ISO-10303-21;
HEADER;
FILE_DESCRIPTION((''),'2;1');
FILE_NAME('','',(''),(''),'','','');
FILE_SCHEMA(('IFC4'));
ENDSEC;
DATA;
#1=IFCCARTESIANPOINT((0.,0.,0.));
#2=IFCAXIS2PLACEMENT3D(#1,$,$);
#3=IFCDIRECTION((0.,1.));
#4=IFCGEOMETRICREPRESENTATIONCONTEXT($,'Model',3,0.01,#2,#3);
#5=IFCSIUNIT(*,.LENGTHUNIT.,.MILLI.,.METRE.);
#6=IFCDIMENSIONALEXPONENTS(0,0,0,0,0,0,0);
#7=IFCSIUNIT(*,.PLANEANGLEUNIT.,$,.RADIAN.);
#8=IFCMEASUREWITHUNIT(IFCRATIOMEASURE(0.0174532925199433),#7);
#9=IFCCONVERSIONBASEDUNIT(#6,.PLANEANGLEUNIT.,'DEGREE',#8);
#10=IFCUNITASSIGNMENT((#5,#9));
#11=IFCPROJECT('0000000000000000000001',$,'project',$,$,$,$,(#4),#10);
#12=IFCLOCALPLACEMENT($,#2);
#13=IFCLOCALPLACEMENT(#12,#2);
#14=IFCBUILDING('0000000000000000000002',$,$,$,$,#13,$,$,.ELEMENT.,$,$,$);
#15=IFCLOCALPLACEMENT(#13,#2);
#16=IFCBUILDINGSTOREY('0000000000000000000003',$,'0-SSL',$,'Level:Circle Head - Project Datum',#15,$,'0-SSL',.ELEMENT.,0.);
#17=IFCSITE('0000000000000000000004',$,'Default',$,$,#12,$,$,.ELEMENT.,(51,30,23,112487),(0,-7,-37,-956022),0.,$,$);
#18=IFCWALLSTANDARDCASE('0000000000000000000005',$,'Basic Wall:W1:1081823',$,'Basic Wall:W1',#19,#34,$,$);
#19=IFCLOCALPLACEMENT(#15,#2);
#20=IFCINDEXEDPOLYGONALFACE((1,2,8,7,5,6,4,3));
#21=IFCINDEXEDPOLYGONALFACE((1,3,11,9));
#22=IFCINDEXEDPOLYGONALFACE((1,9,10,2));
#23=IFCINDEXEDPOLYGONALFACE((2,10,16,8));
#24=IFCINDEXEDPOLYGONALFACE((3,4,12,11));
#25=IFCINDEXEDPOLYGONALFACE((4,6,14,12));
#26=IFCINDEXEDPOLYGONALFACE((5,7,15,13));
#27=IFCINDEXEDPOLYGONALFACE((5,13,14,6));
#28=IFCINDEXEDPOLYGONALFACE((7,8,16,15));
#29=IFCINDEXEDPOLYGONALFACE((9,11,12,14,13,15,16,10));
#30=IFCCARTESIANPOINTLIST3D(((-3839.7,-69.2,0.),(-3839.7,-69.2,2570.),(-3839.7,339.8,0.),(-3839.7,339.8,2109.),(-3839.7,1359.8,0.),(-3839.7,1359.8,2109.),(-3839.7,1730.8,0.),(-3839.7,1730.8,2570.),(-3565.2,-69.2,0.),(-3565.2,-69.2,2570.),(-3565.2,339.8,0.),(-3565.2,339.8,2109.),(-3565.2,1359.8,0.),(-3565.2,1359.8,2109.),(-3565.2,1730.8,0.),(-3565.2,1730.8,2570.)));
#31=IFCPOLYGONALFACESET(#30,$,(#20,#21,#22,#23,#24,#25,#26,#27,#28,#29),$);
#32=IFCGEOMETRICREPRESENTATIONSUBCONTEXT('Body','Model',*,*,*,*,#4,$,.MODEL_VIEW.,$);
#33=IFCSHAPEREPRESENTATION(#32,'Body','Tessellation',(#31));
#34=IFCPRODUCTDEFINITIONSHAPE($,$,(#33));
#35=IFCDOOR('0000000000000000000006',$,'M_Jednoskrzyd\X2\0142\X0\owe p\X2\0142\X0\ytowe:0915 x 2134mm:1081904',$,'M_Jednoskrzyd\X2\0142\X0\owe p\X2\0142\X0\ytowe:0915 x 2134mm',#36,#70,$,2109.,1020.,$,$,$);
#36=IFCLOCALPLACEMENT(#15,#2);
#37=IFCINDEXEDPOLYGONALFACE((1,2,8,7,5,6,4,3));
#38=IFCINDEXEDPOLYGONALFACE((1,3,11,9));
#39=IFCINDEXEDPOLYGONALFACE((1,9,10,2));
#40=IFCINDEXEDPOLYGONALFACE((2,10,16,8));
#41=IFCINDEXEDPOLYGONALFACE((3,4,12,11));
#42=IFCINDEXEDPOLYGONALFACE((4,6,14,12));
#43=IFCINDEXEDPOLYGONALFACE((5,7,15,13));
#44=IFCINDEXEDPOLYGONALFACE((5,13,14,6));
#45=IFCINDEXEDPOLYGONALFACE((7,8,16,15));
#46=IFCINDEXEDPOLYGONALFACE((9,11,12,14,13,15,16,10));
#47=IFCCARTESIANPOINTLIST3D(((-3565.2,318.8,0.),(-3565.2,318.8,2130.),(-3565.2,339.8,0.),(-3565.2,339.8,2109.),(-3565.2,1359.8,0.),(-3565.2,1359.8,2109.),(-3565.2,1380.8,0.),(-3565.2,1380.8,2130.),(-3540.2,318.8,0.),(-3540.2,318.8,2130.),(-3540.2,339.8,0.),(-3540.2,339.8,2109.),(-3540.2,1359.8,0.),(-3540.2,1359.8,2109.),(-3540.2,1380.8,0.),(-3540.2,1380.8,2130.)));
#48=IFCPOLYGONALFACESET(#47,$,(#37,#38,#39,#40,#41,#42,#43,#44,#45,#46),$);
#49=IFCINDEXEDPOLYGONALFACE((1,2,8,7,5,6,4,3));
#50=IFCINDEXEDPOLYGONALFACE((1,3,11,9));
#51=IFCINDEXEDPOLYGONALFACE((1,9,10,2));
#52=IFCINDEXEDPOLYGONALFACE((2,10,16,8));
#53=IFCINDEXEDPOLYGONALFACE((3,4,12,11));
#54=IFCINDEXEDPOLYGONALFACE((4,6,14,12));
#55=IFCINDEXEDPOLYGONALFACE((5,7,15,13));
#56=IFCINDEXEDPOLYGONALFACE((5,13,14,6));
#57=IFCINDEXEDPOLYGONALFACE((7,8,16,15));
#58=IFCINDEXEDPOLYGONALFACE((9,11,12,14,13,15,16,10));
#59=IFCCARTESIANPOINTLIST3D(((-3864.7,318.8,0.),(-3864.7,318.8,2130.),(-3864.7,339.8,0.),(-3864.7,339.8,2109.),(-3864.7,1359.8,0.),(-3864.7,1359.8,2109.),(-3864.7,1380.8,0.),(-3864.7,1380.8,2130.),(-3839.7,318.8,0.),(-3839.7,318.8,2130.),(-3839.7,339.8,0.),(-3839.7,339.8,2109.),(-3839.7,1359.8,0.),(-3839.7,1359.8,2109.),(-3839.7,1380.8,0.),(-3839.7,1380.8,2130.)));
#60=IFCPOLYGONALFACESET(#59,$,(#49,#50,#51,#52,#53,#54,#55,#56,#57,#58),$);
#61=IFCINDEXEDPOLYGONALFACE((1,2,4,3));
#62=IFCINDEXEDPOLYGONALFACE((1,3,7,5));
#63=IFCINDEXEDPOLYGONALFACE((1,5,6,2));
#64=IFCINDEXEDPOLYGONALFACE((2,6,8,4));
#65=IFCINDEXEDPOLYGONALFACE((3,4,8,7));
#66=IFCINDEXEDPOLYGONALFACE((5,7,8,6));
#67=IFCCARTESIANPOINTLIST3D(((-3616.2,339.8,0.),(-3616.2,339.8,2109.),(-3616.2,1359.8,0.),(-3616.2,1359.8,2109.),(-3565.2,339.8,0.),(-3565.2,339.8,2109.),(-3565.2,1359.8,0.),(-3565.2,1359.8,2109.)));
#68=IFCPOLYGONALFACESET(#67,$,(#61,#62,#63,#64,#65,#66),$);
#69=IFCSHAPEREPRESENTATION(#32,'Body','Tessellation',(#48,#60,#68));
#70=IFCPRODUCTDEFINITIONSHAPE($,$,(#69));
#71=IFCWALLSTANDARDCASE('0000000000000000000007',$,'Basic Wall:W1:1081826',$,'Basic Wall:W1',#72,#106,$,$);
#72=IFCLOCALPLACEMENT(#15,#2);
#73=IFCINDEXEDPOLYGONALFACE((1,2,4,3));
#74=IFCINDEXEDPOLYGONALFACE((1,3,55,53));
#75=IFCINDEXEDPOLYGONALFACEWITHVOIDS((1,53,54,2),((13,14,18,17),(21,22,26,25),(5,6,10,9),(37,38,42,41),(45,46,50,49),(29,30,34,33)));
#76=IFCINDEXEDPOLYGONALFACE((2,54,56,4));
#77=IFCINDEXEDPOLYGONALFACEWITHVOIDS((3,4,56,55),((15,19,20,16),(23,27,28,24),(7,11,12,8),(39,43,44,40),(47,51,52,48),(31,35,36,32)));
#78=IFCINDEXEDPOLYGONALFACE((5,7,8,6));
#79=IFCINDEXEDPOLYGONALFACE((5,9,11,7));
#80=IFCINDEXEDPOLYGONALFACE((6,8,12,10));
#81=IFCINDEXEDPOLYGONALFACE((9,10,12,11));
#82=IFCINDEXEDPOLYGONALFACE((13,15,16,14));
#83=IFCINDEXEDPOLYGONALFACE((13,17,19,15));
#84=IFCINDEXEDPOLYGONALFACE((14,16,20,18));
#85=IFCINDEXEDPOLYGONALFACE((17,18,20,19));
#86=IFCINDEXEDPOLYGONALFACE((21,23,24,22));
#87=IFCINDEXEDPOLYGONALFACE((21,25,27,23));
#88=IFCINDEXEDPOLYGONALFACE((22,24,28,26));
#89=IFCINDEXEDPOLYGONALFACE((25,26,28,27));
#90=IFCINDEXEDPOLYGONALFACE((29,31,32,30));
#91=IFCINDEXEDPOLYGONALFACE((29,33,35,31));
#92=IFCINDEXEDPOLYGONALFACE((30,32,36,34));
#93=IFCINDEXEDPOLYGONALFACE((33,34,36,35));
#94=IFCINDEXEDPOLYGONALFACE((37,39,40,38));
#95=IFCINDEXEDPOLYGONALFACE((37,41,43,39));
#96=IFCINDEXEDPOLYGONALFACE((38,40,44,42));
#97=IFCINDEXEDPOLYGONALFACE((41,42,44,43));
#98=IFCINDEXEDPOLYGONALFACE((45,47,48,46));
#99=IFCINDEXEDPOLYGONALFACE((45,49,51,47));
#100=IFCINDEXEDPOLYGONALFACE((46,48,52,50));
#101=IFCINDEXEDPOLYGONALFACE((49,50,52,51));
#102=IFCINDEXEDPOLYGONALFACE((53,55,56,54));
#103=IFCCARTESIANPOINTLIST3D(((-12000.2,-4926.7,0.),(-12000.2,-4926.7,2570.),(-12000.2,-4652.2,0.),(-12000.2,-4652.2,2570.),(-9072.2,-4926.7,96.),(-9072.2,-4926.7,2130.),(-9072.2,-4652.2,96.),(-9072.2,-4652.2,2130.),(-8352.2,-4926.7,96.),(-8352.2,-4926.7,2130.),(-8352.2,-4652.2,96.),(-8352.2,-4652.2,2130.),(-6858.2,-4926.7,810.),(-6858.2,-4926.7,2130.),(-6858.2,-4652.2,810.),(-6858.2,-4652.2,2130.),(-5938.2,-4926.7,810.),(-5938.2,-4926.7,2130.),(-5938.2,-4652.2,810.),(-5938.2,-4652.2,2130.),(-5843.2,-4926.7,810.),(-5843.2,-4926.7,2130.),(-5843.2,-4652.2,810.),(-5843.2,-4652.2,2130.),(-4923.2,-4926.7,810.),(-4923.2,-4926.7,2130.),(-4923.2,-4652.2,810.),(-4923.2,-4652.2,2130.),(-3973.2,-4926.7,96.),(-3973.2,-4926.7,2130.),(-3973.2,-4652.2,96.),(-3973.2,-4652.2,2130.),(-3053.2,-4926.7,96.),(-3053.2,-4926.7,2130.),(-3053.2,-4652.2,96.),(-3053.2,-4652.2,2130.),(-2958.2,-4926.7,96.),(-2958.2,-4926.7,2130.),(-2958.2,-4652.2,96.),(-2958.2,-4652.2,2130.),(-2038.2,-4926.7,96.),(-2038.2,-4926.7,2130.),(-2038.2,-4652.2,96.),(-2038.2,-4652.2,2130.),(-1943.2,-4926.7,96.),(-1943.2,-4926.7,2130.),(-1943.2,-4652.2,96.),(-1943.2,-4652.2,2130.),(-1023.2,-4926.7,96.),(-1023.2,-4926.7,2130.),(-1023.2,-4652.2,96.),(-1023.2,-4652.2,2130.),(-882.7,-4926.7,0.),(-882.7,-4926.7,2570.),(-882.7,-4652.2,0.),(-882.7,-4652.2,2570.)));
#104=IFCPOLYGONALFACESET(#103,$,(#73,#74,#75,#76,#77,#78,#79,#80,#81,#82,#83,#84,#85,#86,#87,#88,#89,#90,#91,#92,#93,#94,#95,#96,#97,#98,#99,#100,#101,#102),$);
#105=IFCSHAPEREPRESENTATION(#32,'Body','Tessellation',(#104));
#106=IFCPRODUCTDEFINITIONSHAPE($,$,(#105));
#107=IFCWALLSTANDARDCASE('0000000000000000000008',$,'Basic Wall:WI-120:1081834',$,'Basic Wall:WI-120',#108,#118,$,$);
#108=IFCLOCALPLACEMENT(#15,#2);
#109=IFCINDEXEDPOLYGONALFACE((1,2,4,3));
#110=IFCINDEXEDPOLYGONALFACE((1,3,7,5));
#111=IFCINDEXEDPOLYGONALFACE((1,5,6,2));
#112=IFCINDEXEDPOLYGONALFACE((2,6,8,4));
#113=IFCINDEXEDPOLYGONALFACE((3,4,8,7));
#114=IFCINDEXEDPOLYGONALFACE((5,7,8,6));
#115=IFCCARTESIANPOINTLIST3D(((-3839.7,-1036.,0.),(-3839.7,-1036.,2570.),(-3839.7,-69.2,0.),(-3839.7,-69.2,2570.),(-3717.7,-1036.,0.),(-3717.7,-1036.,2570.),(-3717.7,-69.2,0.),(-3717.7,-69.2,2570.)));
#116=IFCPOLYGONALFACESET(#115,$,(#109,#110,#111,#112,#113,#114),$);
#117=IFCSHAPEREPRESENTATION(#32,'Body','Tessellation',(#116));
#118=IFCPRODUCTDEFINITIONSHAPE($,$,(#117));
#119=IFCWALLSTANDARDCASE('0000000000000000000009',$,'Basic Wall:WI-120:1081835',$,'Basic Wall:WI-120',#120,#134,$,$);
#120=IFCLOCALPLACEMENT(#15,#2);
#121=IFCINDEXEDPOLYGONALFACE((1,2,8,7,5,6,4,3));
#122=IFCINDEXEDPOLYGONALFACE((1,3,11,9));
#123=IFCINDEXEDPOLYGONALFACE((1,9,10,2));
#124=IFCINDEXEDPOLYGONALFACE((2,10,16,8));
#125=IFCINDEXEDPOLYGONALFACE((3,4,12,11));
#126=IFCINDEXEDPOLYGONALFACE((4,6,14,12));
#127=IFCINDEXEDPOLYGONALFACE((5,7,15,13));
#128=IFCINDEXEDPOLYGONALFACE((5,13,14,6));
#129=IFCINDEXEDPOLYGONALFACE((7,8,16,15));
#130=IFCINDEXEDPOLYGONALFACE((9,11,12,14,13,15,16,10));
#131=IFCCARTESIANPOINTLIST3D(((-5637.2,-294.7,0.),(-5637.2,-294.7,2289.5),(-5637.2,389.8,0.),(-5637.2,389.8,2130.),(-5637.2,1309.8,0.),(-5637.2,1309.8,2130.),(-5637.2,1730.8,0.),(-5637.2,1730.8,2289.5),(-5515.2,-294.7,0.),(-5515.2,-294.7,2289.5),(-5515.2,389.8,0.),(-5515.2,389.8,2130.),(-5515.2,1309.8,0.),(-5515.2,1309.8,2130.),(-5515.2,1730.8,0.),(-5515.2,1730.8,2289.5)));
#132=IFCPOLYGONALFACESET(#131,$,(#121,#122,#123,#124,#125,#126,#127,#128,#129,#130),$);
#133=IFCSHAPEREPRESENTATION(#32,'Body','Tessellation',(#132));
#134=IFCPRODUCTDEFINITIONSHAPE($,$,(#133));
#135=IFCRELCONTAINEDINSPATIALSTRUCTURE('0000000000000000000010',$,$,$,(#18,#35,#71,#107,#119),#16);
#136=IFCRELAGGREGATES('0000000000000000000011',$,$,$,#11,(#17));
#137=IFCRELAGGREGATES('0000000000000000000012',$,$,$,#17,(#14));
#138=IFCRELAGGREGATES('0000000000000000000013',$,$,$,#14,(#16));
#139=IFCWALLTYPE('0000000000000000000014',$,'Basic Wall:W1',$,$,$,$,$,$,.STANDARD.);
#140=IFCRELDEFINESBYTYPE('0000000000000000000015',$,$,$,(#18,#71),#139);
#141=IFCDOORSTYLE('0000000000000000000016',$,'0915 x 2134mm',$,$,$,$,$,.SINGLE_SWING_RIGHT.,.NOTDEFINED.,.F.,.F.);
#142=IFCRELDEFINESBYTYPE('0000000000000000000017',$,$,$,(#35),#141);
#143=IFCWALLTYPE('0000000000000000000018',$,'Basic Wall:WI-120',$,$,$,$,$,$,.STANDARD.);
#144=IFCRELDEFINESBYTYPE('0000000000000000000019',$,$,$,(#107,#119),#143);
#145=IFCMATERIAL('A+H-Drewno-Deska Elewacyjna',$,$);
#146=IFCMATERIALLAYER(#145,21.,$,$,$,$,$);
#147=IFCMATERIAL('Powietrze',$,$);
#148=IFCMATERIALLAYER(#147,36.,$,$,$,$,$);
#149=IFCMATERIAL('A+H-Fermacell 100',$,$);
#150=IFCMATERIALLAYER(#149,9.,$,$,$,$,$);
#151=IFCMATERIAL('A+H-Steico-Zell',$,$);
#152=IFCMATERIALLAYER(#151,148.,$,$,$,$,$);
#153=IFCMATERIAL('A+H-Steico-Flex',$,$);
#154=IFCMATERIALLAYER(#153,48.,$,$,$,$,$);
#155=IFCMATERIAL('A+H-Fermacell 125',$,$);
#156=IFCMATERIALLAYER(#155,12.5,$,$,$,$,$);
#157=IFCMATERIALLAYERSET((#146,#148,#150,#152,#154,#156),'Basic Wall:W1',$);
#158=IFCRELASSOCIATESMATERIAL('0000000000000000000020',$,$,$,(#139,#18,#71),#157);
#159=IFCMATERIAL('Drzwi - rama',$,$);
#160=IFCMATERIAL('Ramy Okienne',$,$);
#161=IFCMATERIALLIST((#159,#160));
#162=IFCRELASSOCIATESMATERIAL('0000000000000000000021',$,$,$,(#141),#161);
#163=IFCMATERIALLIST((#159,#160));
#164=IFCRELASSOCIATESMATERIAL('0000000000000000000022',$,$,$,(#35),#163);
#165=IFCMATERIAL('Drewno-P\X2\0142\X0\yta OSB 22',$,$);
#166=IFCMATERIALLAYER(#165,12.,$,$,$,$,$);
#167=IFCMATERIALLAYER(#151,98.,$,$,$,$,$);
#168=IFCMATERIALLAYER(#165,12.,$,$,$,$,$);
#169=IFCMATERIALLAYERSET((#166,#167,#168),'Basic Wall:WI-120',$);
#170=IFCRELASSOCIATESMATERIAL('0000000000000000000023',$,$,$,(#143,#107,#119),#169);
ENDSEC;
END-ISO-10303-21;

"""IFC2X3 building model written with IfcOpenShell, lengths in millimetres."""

from ifc_helpers import new_model, entity, si_unit, converted_unit, direction, frame, frame_2d, origin, place, context, subcontext, project, spatial, polyline, rectangle, outline, extrude, clip, bounded_halfspace, source, transform, mapped, material, material_list, layer, layer_set, layer_usage, type_object, type_shapes, element, fill, save


model = new_model("IFC2X3")

# Units and contexts
model_context = context("Model", 3, precision=0.01, world=origin(), true_north=direction((0.0, 1.0)))
body_context = subcontext(model_context, "Body", "Model", "MODEL_VIEW")
ifc_project = project(units=[si_unit("LENGTHUNIT", "METRE", prefix="MILLI"), converted_unit("PLANEANGLEUNIT", "DEGREE", entity("IfcRatioMeasure", 0.0174532925199433), si_unit("PLANEANGLEUNIT", "RADIAN"), dimensions=[0, 0, 0, 0, 0, 0, 0])], contexts=[model_context])

# Site, building, storey
site_placement = place(None, origin())
site = spatial("IfcSite", under=ifc_project, at=site_placement, Name="Default", CompositionType="ELEMENT", RefLatitude=(51, 30, 23, 112487), RefLongitude=(0, -7, -37, -956022), RefElevation=0.0)
building_placement = place(site_placement, origin())
building = spatial("IfcBuilding", under=site, at=building_placement, CompositionType="ELEMENT")
storey_placement = place(building_placement, origin())
storey = spatial("IfcBuildingStorey", under=building, at=storey_placement, Name="0-SSL", ObjectType="Level:Circle Head - Project Datum", LongName="0-SSL", CompositionType="ELEMENT", Elevation=0.0)

# Wall, opening, door
ifc_material_1 = material(Name="A+H-Drewno-Deska Elewacyjna")
ifc_layer_1 = layer(ifc_material_1, 21.0)
ifc_material_2 = material(Name="Powietrze")
ifc_layer_2 = layer(ifc_material_2, 36.0)
ifc_material_3 = material(Name="A+H-Fermacell 100")
ifc_layer_3 = layer(ifc_material_3, 9.0)
ifc_material_4 = material(Name="A+H-Steico-Zell")
ifc_layer_4 = layer(ifc_material_4, 148.0)
ifc_material_5 = material(Name="A+H-Steico-Flex")
ifc_layer_5 = layer(ifc_material_5, 48.0)
ifc_material_6 = material(Name="A+H-Fermacell 125")
ifc_layer_6 = layer(ifc_material_6, 12.5)
ifc_layer_set_1 = layer_set([ifc_layer_1, ifc_layer_2, ifc_layer_3, ifc_layer_4, ifc_layer_5, ifc_layer_6], Name="Basic Wall:W1")
ifc_layer_usage_1 = layer_usage(ifc_layer_set_1, "AXIS2", "NEGATIVE", 137.2)
wall_type_1 = type_object("IfcWallType", Name="Basic Wall:W1", PredefinedType="STANDARD", material=ifc_layer_set_1)
wall_1_placement = place(storey_placement, frame((-3702.4, 1730.8, 0.0), z_axis=(0.0, 0.0, 1.0), x_axis=(0.0, -1.0, 0.0)))
wall_1 = element("IfcWallStandardCase", 1, at=wall_1_placement, inside=storey, type_object=wall_type_1, material=ifc_layer_usage_1, Name="Basic Wall:W1:1081823", ObjectType="Basic Wall:W1", context=body_context, shape_type="SweptSolid", body=[
    extrude(rectangle(XDim=1800.0, YDim=274.5, at=frame_2d((900.0, 0.0), x_axis=(-1.0, 0.0))), origin(), (0.0, 0.0, 1.0), 2570.0),
])
opening_1_placement = place(wall_1_placement, frame((371.0, -137.3, 0.0)))
opening_1 = element("IfcOpeningElement", 2, at=opening_1_placement, cuts=wall_1, ObjectType="Opening", context=body_context, shape_type="SweptSolid", body=[
    extrude(rectangle(XDim=1020.0, YDim=2109.0, at=frame_2d((1054.5, 510.0), x_axis=(0.0, 1.0))), frame((0.0, 0.0, 0.0), z_axis=(0.0, 1.0, 0.0), x_axis=(0.0, 0.0, 1.0)), (0.0, 0.0, 1.0), 274.5),
])
ifc_material_7 = material(Name="Drzwi - rama")
ifc_material_8 = material(Name="Ramy Okienne")
ifc_material_list_1 = material_list([ifc_material_7, ifc_material_8])
ifc_material_list_2 = material_list([ifc_material_7, ifc_material_8])
door_style = type_object("IfcDoorStyle", Name="0915 x 2134mm", ConstructionType="NOTDEFINED", OperationType="SINGLE_SWING_RIGHT", ParameterTakesPrecedence=False, Sizeable=False, material=ifc_material_list_2)
shared_shape_1 = source(origin(), body_context, "Body", "SweptSolid", [
    extrude(outline(polyline([(-531.0, -1070.2), (531.0, -1070.2), (531.0, 1059.8), (510.0, 1059.8), (510.0, -1049.2), (-510.0, -1049.2), (-510.0, 1059.8), (-531.0, 1059.8), (-531.0, -1070.2)])), frame((510.0, 274.5, 1059.8), z_axis=(0.0, 1.0, 0.0), x_axis=(1.0, 0.0, 0.0)), (0.0, 0.0, 1.0), 25.0),
    extrude(outline(polyline([(-1070.2, -531.0), (1059.8, -531.0), (1059.8, -510.0), (-1049.2, -510.0), (-1049.2, 510.0), (1059.8, 510.0), (1059.8, 531.0), (-1070.2, 531.0), (-1070.2, -531.0)])), frame((510.0, -25.0, 1059.8), z_axis=(0.0, 1.0, 0.0), x_axis=(0.0, 0.0, -1.0)), (0.0, 0.0, 1.0), 25.0),
    extrude(rectangle(XDim=51.0, YDim=1020.0, at=frame_2d((0.0, 0.0), x_axis=(1.0, 0.0))), frame((510.0, 249.0, 0.0), z_axis=(0.0, 0.0, 1.0), x_axis=(0.0, 1.0, 0.0)), (0.0, 0.0, 1.0), 2109.0),
])
type_shapes(door_style, [shared_shape_1])
door_placement = place(opening_1_placement, origin())
door = element("IfcDoor", 3, at=door_placement, inside=storey, type_object=door_style, material=ifc_material_list_1, Name="M_Jednoskrzydłowe płytowe:0915 x 2134mm:1081904", ObjectType="M_Jednoskrzydłowe płytowe:0915 x 2134mm", OverallHeight=2109.0, OverallWidth=1020.0, context=body_context, shape_type="MappedRepresentation", body=[
    mapped(shared_shape_1, transform((0.0, 0.0, 0.0), scale=1.0)),
])
fill(opening_1, door)

# Wall, openings
ifc_layer_usage_2 = layer_usage(ifc_layer_set_1, "AXIS2", "NEGATIVE", 137.2)
wall_2_placement = place(storey_placement, frame((-882.7, -4789.5, 0.0), z_axis=(0.0, 0.0, 1.0), x_axis=(-1.0, 0.0, 0.0)))
wall_2 = element("IfcWallStandardCase", 4, at=wall_2_placement, inside=storey, type_object=wall_type_1, material=ifc_layer_usage_2, Name="Basic Wall:W1:1081826", ObjectType="Basic Wall:W1", context=body_context, shape_type="SweptSolid", body=[
    extrude(rectangle(XDim=11117.5, YDim=274.5, at=frame_2d((5558.8, 0.0), x_axis=(-1.0, 0.0))), origin(), (0.0, 0.0, 1.0), 2570.0),
])
opening_2_placement = place(wall_2_placement, frame((4040.5, -137.3, 810.0)))
element("IfcOpeningElement", 5, at=opening_2_placement, cuts=wall_2, ObjectType="Opening", context=body_context, shape_type="SweptSolid", body=[
    extrude(rectangle(XDim=1320.0, YDim=920.0, at=frame_2d((660.0, 460.0), x_axis=(-1.0, 0.0))), frame((0.0, 0.0, 0.0), z_axis=(0.0, 1.0, 0.0), x_axis=(0.0, 0.0, 1.0)), (0.0, 0.0, 1.0), 274.5),
])
opening_3_placement = place(wall_2_placement, frame((5055.5, -137.3, 810.0)))
element("IfcOpeningElement", 6, at=opening_3_placement, cuts=wall_2, ObjectType="Opening", context=body_context, shape_type="SweptSolid", body=[
    extrude(rectangle(XDim=1320.0, YDim=920.0, at=frame_2d((660.0, 460.0), x_axis=(-1.0, 0.0))), frame((0.0, 0.0, 0.0), z_axis=(0.0, 1.0, 0.0), x_axis=(0.0, 0.0, 1.0)), (0.0, 0.0, 1.0), 274.5),
])
opening_4_placement = place(wall_2_placement, frame((7469.5, -137.3, 96.0)))
element("IfcOpeningElement", 7, at=opening_4_placement, cuts=wall_2, ObjectType="Opening", context=body_context, shape_type="SweptSolid", body=[
    extrude(rectangle(XDim=2034.0, YDim=720.0, at=frame_2d((1017.0, 360.0), x_axis=(-1.0, 0.0))), frame((0.0, 0.0, 0.0), z_axis=(0.0, 1.0, 0.0), x_axis=(0.0, 0.0, 1.0)), (0.0, 0.0, 1.0), 274.5),
])
opening_5_placement = place(wall_2_placement, frame((1155.5, -137.3, 96.0)))
element("IfcOpeningElement", 8, at=opening_5_placement, cuts=wall_2, ObjectType="Opening", context=body_context, shape_type="SweptSolid", body=[
    extrude(rectangle(XDim=2034.0, YDim=920.0, at=frame_2d((1017.0, 460.0), x_axis=(-1.0, 0.0))), frame((0.0, 0.0, 0.0), z_axis=(0.0, 1.0, 0.0), x_axis=(0.0, 0.0, 1.0)), (0.0, 0.0, 1.0), 274.5),
])
opening_6_placement = place(wall_2_placement, frame((2170.5, -137.3, 96.0)))
element("IfcOpeningElement", 9, at=opening_6_placement, cuts=wall_2, ObjectType="Opening", context=body_context, shape_type="SweptSolid", body=[
    extrude(rectangle(XDim=2034.0, YDim=920.0, at=frame_2d((1017.0, 460.0), x_axis=(-1.0, 0.0))), frame((0.0, 0.0, 0.0), z_axis=(0.0, 1.0, 0.0), x_axis=(0.0, 0.0, 1.0)), (0.0, 0.0, 1.0), 274.5),
])
opening_7_placement = place(wall_2_placement, frame((140.5, -137.2, 96.0)))
element("IfcOpeningElement", 10, at=opening_7_placement, cuts=wall_2, ObjectType="Opening", context=body_context, shape_type="SweptSolid", body=[
    extrude(rectangle(XDim=2034.0, YDim=920.0, at=frame_2d((1017.0, 460.0), x_axis=(-1.0, 0.0))), frame((0.0, 0.0, 0.0), z_axis=(0.0, 1.0, 0.0), x_axis=(0.0, 0.0, 1.0)), (0.0, 0.0, 1.0), 274.5),
])

# Wall
ifc_material_9 = material(Name="Drewno-Płyta OSB 22")
ifc_layer_7 = layer(ifc_material_9, 12.0)
ifc_layer_8 = layer(ifc_material_4, 98.0)
ifc_layer_9 = layer(ifc_material_9, 12.0)
ifc_layer_set_2 = layer_set([ifc_layer_7, ifc_layer_8, ifc_layer_9], Name="Basic Wall:WI-120")
ifc_layer_usage_3 = layer_usage(ifc_layer_set_2, "AXIS2", "NEGATIVE", 61.0)
wall_type_2 = type_object("IfcWallType", Name="Basic Wall:WI-120", PredefinedType="STANDARD", material=ifc_layer_set_2)
wall_3_placement = place(storey_placement, frame((-3778.7, -69.2, 0.0), z_axis=(0.0, 0.0, 1.0), x_axis=(0.0, -1.0, 0.0)))
element("IfcWallStandardCase", 11, at=wall_3_placement, inside=storey, type_object=wall_type_2, material=ifc_layer_usage_3, Name="Basic Wall:WI-120:1081834", ObjectType="Basic Wall:WI-120", context=body_context, shape_type="SweptSolid", body=[
    extrude(rectangle(XDim=966.8, YDim=122.0, at=frame_2d((483.4, 0.0), x_axis=(-1.0, 0.0))), origin(), (0.0, 0.0, 1.0), 2570.0),
])

# Wall, opening
ifc_layer_usage_4 = layer_usage(ifc_layer_set_2, "AXIS2", "POSITIVE", -61.0)
wall_4_placement = place(storey_placement, frame((-5576.2, -294.7, 0.0), z_axis=(0.0, 0.0, 1.0), x_axis=(0.0, 1.0, 0.0)))
wall_4 = element("IfcWallStandardCase", 12, at=wall_4_placement, inside=storey, type_object=wall_type_2, material=ifc_layer_usage_4, Name="Basic Wall:WI-120:1081835", ObjectType="Basic Wall:WI-120", context=body_context, shape_type="Clipping", body=[
    clip(extrude(rectangle(XDim=2025.5, YDim=122.0, at=frame_2d((1012.8, 0.0), x_axis=(-1.0, 0.0))), origin(), (0.0, 0.0, 1.0), 2289.5), bounded_halfspace(frame((0.0, -61.0, 2289.5), z_axis=(0.0, 0.0, -1.0), x_axis=(-1.0, 0.0, 0.0)), True, frame((0.0, -61.0, 2289.5)), polyline([(0.0, 0.0), (2025.5, 0.0), (2025.5, 122.0), (0.0, 122.0), (0.0, 0.0)]))),
])
opening_8_placement = place(wall_4_placement, frame((684.5, -61.0, 0.0)))
element("IfcOpeningElement", 13, at=opening_8_placement, cuts=wall_4, ObjectType="Opening", context=body_context, shape_type="SweptSolid", body=[
    extrude(rectangle(XDim=2130.0, YDim=920.0, at=frame_2d((1065.0, 460.0), x_axis=(1.0, 0.0))), frame((0.0, 0.0, 0.0), z_axis=(0.0, 1.0, 0.0), x_axis=(0.0, 0.0, 1.0)), (0.0, 0.0, 1.0), 122.0),
])

save(model, "model.ifc")
